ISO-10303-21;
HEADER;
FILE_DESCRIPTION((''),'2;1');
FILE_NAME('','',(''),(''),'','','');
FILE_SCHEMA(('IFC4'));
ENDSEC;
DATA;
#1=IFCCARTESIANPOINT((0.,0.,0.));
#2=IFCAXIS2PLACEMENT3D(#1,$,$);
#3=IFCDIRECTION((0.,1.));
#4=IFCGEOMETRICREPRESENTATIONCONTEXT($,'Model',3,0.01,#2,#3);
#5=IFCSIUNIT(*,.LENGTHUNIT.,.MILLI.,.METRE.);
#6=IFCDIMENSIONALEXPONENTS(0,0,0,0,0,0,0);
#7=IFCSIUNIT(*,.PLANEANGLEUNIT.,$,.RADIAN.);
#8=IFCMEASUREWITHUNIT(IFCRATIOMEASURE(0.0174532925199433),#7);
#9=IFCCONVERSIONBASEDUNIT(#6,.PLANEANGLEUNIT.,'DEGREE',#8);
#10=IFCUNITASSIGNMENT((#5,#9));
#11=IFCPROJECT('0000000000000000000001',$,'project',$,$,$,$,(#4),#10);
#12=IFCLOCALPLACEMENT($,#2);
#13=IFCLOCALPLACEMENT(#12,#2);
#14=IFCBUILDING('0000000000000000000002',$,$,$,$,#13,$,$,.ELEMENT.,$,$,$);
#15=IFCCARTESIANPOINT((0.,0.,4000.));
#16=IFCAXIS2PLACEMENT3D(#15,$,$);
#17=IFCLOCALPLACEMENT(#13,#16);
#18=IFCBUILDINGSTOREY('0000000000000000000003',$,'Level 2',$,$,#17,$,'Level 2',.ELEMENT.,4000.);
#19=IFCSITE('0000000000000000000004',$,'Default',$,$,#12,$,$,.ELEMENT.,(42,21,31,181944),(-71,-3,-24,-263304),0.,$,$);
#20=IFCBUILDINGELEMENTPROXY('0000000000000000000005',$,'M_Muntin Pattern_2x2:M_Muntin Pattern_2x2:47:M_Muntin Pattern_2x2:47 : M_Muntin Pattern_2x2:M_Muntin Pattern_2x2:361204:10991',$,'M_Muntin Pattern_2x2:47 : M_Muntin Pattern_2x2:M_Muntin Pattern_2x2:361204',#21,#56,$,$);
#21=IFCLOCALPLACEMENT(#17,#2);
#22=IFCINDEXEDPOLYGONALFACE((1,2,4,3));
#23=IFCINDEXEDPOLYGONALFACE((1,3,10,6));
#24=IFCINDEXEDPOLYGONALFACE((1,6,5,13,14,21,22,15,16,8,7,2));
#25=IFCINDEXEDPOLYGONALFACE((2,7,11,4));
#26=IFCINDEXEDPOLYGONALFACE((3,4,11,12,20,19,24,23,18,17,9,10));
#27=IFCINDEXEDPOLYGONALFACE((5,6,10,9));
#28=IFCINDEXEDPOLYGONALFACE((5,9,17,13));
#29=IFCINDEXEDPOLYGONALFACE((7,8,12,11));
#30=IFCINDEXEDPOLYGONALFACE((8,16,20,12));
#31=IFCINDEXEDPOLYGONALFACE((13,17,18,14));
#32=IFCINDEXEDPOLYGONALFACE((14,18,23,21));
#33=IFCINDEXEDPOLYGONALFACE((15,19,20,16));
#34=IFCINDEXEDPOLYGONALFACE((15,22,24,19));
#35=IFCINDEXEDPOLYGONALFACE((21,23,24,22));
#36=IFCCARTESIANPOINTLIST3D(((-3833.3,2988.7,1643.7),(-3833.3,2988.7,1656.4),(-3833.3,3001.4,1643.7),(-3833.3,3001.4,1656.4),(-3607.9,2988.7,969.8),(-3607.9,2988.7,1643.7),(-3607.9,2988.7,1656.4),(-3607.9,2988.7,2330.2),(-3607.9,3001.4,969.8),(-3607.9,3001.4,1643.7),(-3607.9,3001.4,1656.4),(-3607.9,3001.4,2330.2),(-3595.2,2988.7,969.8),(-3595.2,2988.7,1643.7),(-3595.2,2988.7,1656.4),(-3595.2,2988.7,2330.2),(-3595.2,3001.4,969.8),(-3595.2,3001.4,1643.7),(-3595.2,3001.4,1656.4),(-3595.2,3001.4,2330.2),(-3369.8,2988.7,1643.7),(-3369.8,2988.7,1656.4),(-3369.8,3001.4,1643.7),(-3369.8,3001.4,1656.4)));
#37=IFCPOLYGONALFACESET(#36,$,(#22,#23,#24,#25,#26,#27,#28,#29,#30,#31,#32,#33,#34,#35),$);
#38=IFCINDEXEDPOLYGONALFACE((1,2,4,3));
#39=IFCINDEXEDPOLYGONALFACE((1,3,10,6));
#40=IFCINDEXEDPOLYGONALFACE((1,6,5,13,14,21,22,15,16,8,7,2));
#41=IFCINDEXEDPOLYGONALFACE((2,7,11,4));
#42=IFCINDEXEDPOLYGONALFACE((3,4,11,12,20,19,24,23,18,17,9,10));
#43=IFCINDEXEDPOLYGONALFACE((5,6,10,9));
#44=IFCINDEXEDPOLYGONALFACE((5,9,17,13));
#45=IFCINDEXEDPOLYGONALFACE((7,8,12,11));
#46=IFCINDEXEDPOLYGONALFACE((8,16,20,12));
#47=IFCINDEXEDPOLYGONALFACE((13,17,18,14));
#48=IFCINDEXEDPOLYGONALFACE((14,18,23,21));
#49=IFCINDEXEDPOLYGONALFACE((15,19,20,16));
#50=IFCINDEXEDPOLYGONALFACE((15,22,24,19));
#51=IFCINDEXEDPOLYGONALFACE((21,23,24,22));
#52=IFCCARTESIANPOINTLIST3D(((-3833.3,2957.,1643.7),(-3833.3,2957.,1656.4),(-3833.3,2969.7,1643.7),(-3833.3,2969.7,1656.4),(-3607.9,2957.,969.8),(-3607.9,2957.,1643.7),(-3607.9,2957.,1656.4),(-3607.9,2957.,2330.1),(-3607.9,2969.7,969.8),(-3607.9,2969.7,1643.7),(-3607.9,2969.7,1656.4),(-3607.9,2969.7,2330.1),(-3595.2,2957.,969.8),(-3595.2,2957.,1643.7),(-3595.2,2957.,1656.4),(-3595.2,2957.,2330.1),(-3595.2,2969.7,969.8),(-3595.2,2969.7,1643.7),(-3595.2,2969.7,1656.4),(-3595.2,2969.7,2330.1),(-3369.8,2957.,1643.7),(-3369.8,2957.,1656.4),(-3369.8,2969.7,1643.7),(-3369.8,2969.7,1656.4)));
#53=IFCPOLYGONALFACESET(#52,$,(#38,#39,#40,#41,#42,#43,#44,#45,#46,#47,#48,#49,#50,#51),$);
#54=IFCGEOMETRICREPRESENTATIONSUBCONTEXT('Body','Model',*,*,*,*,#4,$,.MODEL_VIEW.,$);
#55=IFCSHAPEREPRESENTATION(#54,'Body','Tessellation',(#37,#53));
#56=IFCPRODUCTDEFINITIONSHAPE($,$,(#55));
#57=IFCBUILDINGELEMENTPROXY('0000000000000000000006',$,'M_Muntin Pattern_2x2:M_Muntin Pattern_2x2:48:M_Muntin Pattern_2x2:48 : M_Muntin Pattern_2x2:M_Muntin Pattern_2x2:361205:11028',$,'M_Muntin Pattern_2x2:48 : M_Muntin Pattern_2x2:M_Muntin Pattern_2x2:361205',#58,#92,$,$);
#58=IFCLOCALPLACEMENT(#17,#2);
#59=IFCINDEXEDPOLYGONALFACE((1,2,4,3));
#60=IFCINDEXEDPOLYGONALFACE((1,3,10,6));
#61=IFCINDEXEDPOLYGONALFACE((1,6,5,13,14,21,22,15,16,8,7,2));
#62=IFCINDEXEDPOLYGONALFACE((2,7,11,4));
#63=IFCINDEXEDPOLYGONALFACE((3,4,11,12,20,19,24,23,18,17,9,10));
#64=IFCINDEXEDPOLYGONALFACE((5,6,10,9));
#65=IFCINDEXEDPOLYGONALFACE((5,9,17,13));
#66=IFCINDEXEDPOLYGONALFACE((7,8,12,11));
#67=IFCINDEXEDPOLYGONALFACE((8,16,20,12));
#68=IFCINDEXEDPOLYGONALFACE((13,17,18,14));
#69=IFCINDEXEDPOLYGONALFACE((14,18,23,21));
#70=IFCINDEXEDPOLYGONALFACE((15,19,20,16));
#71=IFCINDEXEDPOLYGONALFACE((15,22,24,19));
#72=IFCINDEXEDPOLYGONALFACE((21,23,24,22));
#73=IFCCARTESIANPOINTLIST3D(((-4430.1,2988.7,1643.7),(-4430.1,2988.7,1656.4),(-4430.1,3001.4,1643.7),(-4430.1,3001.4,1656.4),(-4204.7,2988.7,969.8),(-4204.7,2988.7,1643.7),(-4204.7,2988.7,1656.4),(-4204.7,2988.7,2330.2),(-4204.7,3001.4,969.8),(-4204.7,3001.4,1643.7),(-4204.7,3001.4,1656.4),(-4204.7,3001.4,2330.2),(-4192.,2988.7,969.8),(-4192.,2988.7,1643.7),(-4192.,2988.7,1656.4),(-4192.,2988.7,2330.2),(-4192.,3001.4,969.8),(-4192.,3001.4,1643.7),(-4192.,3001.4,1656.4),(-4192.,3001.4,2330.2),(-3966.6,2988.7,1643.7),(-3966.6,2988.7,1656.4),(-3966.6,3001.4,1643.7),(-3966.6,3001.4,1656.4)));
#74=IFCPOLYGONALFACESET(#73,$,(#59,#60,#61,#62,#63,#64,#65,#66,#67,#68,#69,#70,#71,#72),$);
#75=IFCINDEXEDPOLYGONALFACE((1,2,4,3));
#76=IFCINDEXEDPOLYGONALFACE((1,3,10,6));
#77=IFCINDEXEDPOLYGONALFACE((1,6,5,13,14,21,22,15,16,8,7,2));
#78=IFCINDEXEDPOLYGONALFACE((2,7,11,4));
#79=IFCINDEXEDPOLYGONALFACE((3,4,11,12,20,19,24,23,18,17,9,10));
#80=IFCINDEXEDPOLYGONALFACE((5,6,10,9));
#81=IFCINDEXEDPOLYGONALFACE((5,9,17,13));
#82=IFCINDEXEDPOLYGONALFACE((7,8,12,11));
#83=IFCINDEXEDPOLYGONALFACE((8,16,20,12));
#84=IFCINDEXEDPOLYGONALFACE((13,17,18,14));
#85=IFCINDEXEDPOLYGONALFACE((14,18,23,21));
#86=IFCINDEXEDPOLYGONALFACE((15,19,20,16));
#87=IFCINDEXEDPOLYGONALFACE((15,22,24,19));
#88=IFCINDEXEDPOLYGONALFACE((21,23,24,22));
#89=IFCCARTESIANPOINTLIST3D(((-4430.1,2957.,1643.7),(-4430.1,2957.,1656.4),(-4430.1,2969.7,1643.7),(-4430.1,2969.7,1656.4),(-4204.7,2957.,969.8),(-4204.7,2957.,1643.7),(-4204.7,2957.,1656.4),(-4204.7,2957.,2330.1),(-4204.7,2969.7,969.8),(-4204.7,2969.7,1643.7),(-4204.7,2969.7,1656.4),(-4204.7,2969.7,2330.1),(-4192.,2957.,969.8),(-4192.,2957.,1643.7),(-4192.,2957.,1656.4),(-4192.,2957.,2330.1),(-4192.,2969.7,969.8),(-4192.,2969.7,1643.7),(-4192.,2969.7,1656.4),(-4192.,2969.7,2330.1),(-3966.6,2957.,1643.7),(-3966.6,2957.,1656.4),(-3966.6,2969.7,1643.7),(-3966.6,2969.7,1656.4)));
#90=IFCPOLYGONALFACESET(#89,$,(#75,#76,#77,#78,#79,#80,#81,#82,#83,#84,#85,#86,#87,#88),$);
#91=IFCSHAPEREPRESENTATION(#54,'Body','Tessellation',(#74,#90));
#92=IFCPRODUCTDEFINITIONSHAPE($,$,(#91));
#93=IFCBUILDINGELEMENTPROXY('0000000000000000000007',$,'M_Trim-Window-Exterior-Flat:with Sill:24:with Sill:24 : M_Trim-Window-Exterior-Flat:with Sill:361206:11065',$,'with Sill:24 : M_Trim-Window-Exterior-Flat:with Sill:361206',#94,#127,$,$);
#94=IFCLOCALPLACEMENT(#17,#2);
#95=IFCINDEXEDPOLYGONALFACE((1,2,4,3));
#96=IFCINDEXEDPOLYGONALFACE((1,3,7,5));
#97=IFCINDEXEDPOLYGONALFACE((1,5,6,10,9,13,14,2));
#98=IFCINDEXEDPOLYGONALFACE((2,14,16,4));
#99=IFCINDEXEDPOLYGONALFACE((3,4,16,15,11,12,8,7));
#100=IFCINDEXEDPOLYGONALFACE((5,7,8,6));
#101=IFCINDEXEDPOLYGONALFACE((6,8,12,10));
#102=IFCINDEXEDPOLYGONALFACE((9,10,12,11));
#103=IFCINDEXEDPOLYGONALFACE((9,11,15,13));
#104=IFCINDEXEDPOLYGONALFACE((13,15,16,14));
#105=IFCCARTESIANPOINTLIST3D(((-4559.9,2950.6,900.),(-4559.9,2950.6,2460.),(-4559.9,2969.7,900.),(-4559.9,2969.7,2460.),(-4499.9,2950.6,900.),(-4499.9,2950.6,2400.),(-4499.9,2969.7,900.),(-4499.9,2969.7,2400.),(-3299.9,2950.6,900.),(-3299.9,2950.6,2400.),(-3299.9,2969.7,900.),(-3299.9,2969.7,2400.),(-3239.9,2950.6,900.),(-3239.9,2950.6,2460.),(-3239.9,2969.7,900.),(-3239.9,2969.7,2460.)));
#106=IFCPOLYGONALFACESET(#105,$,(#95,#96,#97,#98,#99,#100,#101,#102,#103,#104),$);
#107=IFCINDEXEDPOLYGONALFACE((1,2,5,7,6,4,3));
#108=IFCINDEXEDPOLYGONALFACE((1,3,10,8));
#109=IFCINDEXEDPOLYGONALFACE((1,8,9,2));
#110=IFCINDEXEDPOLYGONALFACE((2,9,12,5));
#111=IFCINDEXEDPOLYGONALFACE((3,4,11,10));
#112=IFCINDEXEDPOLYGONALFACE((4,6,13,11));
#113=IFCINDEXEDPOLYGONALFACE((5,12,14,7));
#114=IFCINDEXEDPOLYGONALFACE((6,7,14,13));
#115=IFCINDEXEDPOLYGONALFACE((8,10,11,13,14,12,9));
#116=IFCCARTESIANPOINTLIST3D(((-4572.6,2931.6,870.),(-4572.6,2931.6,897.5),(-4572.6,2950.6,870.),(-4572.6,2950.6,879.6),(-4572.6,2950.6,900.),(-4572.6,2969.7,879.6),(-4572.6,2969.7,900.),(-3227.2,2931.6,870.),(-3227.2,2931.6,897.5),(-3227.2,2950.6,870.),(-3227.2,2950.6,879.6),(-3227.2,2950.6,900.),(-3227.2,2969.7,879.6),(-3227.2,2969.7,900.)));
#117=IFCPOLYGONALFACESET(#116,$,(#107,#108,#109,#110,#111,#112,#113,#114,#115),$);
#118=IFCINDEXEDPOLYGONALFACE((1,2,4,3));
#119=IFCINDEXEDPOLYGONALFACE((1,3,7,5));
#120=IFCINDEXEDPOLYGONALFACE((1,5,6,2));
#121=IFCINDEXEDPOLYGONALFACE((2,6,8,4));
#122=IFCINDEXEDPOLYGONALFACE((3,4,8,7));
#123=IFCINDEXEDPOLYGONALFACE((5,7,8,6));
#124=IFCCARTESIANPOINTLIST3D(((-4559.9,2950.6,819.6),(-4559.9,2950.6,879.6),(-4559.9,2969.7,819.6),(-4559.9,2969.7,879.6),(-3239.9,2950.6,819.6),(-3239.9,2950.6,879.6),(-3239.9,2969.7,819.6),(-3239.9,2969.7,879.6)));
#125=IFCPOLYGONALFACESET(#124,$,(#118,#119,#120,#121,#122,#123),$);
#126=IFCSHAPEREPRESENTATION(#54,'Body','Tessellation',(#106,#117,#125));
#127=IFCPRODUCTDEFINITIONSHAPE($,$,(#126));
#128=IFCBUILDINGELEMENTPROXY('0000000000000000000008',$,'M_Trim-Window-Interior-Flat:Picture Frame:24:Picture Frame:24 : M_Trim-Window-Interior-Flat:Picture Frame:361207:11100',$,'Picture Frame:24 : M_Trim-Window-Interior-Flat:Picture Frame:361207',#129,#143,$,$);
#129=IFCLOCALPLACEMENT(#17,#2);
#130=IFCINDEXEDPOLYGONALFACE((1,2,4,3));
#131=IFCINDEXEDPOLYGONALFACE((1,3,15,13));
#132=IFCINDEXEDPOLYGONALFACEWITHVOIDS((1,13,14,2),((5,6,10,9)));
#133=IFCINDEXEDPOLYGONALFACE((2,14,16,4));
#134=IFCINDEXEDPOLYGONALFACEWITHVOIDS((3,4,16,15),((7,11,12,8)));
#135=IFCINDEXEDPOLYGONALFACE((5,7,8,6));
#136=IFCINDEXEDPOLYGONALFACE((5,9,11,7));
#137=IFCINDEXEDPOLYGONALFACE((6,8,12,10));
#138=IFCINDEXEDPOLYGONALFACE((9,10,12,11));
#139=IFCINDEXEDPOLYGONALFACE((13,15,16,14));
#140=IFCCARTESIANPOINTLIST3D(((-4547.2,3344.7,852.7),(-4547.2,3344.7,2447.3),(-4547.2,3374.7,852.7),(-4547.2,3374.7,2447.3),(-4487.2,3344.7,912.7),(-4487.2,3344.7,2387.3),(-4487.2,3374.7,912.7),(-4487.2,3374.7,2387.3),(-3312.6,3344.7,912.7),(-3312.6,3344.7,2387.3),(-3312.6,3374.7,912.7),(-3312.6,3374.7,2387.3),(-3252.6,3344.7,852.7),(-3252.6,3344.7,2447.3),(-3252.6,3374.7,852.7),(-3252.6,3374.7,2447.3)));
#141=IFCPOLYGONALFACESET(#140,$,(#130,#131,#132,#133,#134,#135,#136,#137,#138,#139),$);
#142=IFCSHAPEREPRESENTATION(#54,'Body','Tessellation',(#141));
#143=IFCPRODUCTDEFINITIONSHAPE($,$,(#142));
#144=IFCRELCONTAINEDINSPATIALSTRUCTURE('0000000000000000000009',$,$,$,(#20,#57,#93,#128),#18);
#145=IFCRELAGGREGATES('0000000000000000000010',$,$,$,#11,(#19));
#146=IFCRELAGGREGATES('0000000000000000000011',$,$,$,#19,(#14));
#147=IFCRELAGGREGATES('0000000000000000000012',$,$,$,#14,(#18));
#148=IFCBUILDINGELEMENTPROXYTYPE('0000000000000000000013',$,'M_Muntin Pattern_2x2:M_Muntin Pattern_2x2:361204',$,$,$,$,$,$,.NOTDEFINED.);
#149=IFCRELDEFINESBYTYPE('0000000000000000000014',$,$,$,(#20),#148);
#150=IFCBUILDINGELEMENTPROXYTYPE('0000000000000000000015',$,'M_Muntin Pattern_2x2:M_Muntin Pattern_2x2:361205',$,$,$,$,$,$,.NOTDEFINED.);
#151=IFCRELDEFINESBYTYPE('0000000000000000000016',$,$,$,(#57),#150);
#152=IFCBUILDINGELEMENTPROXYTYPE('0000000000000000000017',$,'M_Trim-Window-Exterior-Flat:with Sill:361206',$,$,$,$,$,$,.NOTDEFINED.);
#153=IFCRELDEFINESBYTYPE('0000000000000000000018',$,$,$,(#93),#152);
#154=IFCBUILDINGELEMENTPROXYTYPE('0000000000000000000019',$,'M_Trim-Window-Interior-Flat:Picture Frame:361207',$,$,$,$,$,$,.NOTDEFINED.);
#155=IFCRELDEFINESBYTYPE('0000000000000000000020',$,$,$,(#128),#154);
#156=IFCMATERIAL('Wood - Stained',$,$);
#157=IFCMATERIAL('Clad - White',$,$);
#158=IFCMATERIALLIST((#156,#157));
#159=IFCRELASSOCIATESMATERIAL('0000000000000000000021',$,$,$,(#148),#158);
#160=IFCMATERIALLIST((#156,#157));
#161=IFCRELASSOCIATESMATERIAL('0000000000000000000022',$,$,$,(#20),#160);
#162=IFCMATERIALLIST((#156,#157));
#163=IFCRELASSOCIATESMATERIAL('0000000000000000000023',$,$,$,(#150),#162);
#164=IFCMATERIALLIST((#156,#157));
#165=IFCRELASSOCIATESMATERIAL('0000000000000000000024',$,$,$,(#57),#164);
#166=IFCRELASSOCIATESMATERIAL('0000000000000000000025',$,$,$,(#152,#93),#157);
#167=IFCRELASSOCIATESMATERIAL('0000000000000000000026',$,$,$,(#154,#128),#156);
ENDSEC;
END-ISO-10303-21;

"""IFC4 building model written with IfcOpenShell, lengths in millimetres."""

from ifc_helpers import new_model, entity, si_unit, converted_unit, direction, frame, origin, origin_2d_with_axis, place, context, subcontext, project, spatial, polyline, rectangle, outline, extrude, source, transform, mapped, material, material_list, type_object, type_shapes, element, save


model = new_model("IFC4")

# Units and contexts
model_context = context("Model", 3, precision=0.01, world=origin(), true_north=direction((0.0, 1.0)))
body_context = subcontext(model_context, "Body", "Model", "MODEL_VIEW")
ifc_project = project(units=[si_unit("LENGTHUNIT", "METRE", prefix="MILLI"), converted_unit("PLANEANGLEUNIT", "DEGREE", entity("IfcRatioMeasure", 0.0174532925199433), si_unit("PLANEANGLEUNIT", "RADIAN"), dimensions=[0, 0, 0, 0, 0, 0, 0])], contexts=[model_context])

# Site, building, storey
site_placement = place(None, origin())
site = spatial("IfcSite", under=ifc_project, at=site_placement, Name="Default", CompositionType="ELEMENT", RefLatitude=(42, 21, 31, 181944), RefLongitude=(-71, -3, -24, -263304), RefElevation=0.0)
building_placement = place(site_placement, origin())
building = spatial("IfcBuilding", under=site, at=building_placement, CompositionType="ELEMENT")
storey_placement = place(building_placement, frame((0.0, 0.0, 4000.0)))
storey = spatial("IfcBuildingStorey", under=building, at=storey_placement, Name="Level 2", LongName="Level 2", CompositionType="ELEMENT", Elevation=4000.0)

# Building element proxies
ifc_material_1 = material(Name="Wood - Stained")
ifc_material_2 = material(Name="Clad - White")
ifc_material_list_1 = material_list([ifc_material_1, ifc_material_2])
ifc_material_list_2 = material_list([ifc_material_1, ifc_material_2])
building_element_proxy_type_1 = type_object("IfcBuildingElementProxyType", Name="M_Muntin Pattern_2x2:M_Muntin Pattern_2x2:361204", PredefinedType="NOTDEFINED", material=ifc_material_list_2)
shared_shape_1 = source(origin(), body_context, "Body", "SweptSolid", [
    extrude(outline(polyline([(-680.2, 6.4), (-680.2, -6.3), (-6.4, -6.3), (-6.4, -231.7), (6.3, -231.7), (6.3, -6.3), (680.2, -6.3), (680.2, 6.4), (6.3, 6.4), (6.3, 231.7), (-6.4, 231.7), (-6.4, 6.4), (-680.2, 6.4)])), frame((-3601.5, 2988.7, 5650.0), z_axis=(0.0, -1.0, 0.0), x_axis=(0.0, 0.0, -1.0)), (0.0, 0.0, -1.0), 12.7),
    extrude(outline(polyline([(-680.1, 6.4), (-680.1, -6.3), (-6.4, -6.3), (-6.4, -231.7), (6.3, -231.7), (6.3, -6.3), (680.2, -6.3), (680.2, 6.4), (6.3, 6.4), (6.3, 231.7), (-6.4, 231.7), (-6.4, 6.4), (-680.1, 6.4)])), frame((-3601.5, 2957.0, 5650.0), z_axis=(0.0, -1.0, 0.0), x_axis=(0.0, 0.0, -1.0)), (0.0, 0.0, -1.0), 12.7),
])
type_shapes(building_element_proxy_type_1, [shared_shape_1])
proxy_1_placement = place(storey_placement, frame((0.0, 0.0, -4000.0)))
element("IfcBuildingElementProxy", 1, at=proxy_1_placement, inside=storey, type_object=building_element_proxy_type_1, material=ifc_material_list_1, Name="M_Muntin Pattern_2x2:M_Muntin Pattern_2x2:47:M_Muntin Pattern_2x2:47 : M_Muntin Pattern_2x2:M_Muntin Pattern_2x2:361204:10991", ObjectType="M_Muntin Pattern_2x2:47 : M_Muntin Pattern_2x2:M_Muntin Pattern_2x2:361204", context=body_context, shape_type="MappedRepresentation", body=[
    mapped(shared_shape_1, transform((0.0, 0.0, 0.0), scale=1.0)),
])
ifc_material_list_3 = material_list([ifc_material_1, ifc_material_2])
ifc_material_list_4 = material_list([ifc_material_1, ifc_material_2])
building_element_proxy_type_2 = type_object("IfcBuildingElementProxyType", Name="M_Muntin Pattern_2x2:M_Muntin Pattern_2x2:361205", PredefinedType="NOTDEFINED", material=ifc_material_list_4)
shared_shape_2 = source(origin(), body_context, "Body", "SweptSolid", [
    extrude(outline(polyline([(-6.4, -680.1), (6.3, -680.1), (6.3, -6.4), (231.7, -6.4), (231.7, 6.3), (6.3, 6.3), (6.3, 680.2), (-6.4, 680.2), (-6.4, 6.3), (-231.7, 6.3), (-231.7, -6.4), (-6.4, -6.4), (-6.4, -680.1)])), frame((-4198.4, 2988.7, 5650.0), z_axis=(0.0, 1.0, 0.0), x_axis=(1.0, 0.0, 0.0)), (0.0, 0.0, 1.0), 12.7),
    extrude(outline(polyline([(-6.4, -680.1), (6.3, -680.1), (6.3, -6.4), (231.7, -6.4), (231.7, 6.3), (6.3, 6.3), (6.3, 680.2), (-6.4, 680.2), (-6.4, 6.3), (-231.7, 6.3), (-231.7, -6.4), (-6.4, -6.4), (-6.4, -680.1)])), frame((-4198.4, 2957.0, 5650.0), z_axis=(0.0, 1.0, 0.0), x_axis=(1.0, 0.0, 0.0)), (0.0, 0.0, 1.0), 12.7),
])
type_shapes(building_element_proxy_type_2, [shared_shape_2])
proxy_2_placement = place(storey_placement, frame((0.0, 0.0, -4000.0)))
element("IfcBuildingElementProxy", 2, at=proxy_2_placement, inside=storey, type_object=building_element_proxy_type_2, material=ifc_material_list_3, Name="M_Muntin Pattern_2x2:M_Muntin Pattern_2x2:48:M_Muntin Pattern_2x2:48 : M_Muntin Pattern_2x2:M_Muntin Pattern_2x2:361205:11028", ObjectType="M_Muntin Pattern_2x2:48 : M_Muntin Pattern_2x2:M_Muntin Pattern_2x2:361205", context=body_context, shape_type="MappedRepresentation", body=[
    mapped(shared_shape_2, transform((0.0, 0.0, 0.0), scale=1.0)),
])
building_element_proxy_type_3 = type_object("IfcBuildingElementProxyType", Name="M_Trim-Window-Exterior-Flat:with Sill:361206", PredefinedType="NOTDEFINED", material=ifc_material_2)
shared_shape_3 = source(origin(), body_context, "Body", "SweptSolid", [
    extrude(outline(polyline([(-765.0, -660.0), (795.0, -660.0), (795.0, 660.0), (-765.0, 660.0), (-765.0, 600.0), (735.0, 600.0), (735.0, -600.0), (-765.0, -600.0), (-765.0, -660.0)])), frame((-3899.9, 2950.6, 5665.0), z_axis=(0.0, 1.0, 0.0), x_axis=(0.0, 0.0, 1.0)), (0.0, 0.0, 1.0), 19.1),
    extrude(outline(polyline([(-15.2, 0.0), (-15.2, -19.0), (12.3, -19.0), (14.8, 0.0), (14.8, 19.0), (-5.7, 19.0), (-5.7, 0.0), (-15.2, 0.0)])), frame((-4572.6, 2950.6, 4885.2), z_axis=(-1.0, 0.0, 0.0), x_axis=(0.0, 0.0, 1.0)), (0.0, 0.0, -1.0), 1345.4),
    extrude(rectangle(XDim=19.1, YDim=1320.0, at=origin_2d_with_axis()), frame((-3899.9, 2960.1, 4819.6), z_axis=(0.0, 0.0, 1.0), x_axis=(0.0, 1.0, 0.0)), (0.0, 0.0, 1.0), 60.0),
])
type_shapes(building_element_proxy_type_3, [shared_shape_3])
proxy_3_placement = place(storey_placement, frame((0.0, 0.0, -4000.0)))
element("IfcBuildingElementProxy", 3, at=proxy_3_placement, inside=storey, type_object=building_element_proxy_type_3, material=ifc_material_2, Name="M_Trim-Window-Exterior-Flat:with Sill:24:with Sill:24 : M_Trim-Window-Exterior-Flat:with Sill:361206:11065", ObjectType="with Sill:24 : M_Trim-Window-Exterior-Flat:with Sill:361206", context=body_context, shape_type="MappedRepresentation", body=[
    mapped(shared_shape_3, transform((0.0, 0.0, 0.0), scale=1.0)),
])
building_element_proxy_type_4 = type_object("IfcBuildingElementProxyType", Name="M_Trim-Window-Interior-Flat:Picture Frame:361207", PredefinedType="NOTDEFINED", material=ifc_material_1)
shared_shape_4 = source(origin(), body_context, "Body", "SweptSolid", [
    extrude(outline(polyline([(-797.3, -647.3), (797.3, -647.3), (797.3, 647.3), (-797.3, 647.3), (-797.3, -647.3)]), holes=[polyline([(737.3, 587.3), (737.3, -587.3), (-737.3, -587.3), (-737.3, 587.3), (737.3, 587.3)])]), frame((-3899.9, 3344.7, 5650.0), z_axis=(0.0, 1.0, 0.0), x_axis=(0.0, 0.0, -1.0)), (0.0, 0.0, 1.0), 30.0),
])
type_shapes(building_element_proxy_type_4, [shared_shape_4])
proxy_4_placement = place(storey_placement, frame((0.0, 0.0, -4000.0)))
element("IfcBuildingElementProxy", 4, at=proxy_4_placement, inside=storey, type_object=building_element_proxy_type_4, material=ifc_material_1, Name="M_Trim-Window-Interior-Flat:Picture Frame:24:Picture Frame:24 : M_Trim-Window-Interior-Flat:Picture Frame:361207:11100", ObjectType="Picture Frame:24 : M_Trim-Window-Interior-Flat:Picture Frame:361207", context=body_context, shape_type="MappedRepresentation", body=[
    mapped(shared_shape_4, transform((0.0, 0.0, 0.0), scale=1.0)),
])

save(model, "model.ifc")
